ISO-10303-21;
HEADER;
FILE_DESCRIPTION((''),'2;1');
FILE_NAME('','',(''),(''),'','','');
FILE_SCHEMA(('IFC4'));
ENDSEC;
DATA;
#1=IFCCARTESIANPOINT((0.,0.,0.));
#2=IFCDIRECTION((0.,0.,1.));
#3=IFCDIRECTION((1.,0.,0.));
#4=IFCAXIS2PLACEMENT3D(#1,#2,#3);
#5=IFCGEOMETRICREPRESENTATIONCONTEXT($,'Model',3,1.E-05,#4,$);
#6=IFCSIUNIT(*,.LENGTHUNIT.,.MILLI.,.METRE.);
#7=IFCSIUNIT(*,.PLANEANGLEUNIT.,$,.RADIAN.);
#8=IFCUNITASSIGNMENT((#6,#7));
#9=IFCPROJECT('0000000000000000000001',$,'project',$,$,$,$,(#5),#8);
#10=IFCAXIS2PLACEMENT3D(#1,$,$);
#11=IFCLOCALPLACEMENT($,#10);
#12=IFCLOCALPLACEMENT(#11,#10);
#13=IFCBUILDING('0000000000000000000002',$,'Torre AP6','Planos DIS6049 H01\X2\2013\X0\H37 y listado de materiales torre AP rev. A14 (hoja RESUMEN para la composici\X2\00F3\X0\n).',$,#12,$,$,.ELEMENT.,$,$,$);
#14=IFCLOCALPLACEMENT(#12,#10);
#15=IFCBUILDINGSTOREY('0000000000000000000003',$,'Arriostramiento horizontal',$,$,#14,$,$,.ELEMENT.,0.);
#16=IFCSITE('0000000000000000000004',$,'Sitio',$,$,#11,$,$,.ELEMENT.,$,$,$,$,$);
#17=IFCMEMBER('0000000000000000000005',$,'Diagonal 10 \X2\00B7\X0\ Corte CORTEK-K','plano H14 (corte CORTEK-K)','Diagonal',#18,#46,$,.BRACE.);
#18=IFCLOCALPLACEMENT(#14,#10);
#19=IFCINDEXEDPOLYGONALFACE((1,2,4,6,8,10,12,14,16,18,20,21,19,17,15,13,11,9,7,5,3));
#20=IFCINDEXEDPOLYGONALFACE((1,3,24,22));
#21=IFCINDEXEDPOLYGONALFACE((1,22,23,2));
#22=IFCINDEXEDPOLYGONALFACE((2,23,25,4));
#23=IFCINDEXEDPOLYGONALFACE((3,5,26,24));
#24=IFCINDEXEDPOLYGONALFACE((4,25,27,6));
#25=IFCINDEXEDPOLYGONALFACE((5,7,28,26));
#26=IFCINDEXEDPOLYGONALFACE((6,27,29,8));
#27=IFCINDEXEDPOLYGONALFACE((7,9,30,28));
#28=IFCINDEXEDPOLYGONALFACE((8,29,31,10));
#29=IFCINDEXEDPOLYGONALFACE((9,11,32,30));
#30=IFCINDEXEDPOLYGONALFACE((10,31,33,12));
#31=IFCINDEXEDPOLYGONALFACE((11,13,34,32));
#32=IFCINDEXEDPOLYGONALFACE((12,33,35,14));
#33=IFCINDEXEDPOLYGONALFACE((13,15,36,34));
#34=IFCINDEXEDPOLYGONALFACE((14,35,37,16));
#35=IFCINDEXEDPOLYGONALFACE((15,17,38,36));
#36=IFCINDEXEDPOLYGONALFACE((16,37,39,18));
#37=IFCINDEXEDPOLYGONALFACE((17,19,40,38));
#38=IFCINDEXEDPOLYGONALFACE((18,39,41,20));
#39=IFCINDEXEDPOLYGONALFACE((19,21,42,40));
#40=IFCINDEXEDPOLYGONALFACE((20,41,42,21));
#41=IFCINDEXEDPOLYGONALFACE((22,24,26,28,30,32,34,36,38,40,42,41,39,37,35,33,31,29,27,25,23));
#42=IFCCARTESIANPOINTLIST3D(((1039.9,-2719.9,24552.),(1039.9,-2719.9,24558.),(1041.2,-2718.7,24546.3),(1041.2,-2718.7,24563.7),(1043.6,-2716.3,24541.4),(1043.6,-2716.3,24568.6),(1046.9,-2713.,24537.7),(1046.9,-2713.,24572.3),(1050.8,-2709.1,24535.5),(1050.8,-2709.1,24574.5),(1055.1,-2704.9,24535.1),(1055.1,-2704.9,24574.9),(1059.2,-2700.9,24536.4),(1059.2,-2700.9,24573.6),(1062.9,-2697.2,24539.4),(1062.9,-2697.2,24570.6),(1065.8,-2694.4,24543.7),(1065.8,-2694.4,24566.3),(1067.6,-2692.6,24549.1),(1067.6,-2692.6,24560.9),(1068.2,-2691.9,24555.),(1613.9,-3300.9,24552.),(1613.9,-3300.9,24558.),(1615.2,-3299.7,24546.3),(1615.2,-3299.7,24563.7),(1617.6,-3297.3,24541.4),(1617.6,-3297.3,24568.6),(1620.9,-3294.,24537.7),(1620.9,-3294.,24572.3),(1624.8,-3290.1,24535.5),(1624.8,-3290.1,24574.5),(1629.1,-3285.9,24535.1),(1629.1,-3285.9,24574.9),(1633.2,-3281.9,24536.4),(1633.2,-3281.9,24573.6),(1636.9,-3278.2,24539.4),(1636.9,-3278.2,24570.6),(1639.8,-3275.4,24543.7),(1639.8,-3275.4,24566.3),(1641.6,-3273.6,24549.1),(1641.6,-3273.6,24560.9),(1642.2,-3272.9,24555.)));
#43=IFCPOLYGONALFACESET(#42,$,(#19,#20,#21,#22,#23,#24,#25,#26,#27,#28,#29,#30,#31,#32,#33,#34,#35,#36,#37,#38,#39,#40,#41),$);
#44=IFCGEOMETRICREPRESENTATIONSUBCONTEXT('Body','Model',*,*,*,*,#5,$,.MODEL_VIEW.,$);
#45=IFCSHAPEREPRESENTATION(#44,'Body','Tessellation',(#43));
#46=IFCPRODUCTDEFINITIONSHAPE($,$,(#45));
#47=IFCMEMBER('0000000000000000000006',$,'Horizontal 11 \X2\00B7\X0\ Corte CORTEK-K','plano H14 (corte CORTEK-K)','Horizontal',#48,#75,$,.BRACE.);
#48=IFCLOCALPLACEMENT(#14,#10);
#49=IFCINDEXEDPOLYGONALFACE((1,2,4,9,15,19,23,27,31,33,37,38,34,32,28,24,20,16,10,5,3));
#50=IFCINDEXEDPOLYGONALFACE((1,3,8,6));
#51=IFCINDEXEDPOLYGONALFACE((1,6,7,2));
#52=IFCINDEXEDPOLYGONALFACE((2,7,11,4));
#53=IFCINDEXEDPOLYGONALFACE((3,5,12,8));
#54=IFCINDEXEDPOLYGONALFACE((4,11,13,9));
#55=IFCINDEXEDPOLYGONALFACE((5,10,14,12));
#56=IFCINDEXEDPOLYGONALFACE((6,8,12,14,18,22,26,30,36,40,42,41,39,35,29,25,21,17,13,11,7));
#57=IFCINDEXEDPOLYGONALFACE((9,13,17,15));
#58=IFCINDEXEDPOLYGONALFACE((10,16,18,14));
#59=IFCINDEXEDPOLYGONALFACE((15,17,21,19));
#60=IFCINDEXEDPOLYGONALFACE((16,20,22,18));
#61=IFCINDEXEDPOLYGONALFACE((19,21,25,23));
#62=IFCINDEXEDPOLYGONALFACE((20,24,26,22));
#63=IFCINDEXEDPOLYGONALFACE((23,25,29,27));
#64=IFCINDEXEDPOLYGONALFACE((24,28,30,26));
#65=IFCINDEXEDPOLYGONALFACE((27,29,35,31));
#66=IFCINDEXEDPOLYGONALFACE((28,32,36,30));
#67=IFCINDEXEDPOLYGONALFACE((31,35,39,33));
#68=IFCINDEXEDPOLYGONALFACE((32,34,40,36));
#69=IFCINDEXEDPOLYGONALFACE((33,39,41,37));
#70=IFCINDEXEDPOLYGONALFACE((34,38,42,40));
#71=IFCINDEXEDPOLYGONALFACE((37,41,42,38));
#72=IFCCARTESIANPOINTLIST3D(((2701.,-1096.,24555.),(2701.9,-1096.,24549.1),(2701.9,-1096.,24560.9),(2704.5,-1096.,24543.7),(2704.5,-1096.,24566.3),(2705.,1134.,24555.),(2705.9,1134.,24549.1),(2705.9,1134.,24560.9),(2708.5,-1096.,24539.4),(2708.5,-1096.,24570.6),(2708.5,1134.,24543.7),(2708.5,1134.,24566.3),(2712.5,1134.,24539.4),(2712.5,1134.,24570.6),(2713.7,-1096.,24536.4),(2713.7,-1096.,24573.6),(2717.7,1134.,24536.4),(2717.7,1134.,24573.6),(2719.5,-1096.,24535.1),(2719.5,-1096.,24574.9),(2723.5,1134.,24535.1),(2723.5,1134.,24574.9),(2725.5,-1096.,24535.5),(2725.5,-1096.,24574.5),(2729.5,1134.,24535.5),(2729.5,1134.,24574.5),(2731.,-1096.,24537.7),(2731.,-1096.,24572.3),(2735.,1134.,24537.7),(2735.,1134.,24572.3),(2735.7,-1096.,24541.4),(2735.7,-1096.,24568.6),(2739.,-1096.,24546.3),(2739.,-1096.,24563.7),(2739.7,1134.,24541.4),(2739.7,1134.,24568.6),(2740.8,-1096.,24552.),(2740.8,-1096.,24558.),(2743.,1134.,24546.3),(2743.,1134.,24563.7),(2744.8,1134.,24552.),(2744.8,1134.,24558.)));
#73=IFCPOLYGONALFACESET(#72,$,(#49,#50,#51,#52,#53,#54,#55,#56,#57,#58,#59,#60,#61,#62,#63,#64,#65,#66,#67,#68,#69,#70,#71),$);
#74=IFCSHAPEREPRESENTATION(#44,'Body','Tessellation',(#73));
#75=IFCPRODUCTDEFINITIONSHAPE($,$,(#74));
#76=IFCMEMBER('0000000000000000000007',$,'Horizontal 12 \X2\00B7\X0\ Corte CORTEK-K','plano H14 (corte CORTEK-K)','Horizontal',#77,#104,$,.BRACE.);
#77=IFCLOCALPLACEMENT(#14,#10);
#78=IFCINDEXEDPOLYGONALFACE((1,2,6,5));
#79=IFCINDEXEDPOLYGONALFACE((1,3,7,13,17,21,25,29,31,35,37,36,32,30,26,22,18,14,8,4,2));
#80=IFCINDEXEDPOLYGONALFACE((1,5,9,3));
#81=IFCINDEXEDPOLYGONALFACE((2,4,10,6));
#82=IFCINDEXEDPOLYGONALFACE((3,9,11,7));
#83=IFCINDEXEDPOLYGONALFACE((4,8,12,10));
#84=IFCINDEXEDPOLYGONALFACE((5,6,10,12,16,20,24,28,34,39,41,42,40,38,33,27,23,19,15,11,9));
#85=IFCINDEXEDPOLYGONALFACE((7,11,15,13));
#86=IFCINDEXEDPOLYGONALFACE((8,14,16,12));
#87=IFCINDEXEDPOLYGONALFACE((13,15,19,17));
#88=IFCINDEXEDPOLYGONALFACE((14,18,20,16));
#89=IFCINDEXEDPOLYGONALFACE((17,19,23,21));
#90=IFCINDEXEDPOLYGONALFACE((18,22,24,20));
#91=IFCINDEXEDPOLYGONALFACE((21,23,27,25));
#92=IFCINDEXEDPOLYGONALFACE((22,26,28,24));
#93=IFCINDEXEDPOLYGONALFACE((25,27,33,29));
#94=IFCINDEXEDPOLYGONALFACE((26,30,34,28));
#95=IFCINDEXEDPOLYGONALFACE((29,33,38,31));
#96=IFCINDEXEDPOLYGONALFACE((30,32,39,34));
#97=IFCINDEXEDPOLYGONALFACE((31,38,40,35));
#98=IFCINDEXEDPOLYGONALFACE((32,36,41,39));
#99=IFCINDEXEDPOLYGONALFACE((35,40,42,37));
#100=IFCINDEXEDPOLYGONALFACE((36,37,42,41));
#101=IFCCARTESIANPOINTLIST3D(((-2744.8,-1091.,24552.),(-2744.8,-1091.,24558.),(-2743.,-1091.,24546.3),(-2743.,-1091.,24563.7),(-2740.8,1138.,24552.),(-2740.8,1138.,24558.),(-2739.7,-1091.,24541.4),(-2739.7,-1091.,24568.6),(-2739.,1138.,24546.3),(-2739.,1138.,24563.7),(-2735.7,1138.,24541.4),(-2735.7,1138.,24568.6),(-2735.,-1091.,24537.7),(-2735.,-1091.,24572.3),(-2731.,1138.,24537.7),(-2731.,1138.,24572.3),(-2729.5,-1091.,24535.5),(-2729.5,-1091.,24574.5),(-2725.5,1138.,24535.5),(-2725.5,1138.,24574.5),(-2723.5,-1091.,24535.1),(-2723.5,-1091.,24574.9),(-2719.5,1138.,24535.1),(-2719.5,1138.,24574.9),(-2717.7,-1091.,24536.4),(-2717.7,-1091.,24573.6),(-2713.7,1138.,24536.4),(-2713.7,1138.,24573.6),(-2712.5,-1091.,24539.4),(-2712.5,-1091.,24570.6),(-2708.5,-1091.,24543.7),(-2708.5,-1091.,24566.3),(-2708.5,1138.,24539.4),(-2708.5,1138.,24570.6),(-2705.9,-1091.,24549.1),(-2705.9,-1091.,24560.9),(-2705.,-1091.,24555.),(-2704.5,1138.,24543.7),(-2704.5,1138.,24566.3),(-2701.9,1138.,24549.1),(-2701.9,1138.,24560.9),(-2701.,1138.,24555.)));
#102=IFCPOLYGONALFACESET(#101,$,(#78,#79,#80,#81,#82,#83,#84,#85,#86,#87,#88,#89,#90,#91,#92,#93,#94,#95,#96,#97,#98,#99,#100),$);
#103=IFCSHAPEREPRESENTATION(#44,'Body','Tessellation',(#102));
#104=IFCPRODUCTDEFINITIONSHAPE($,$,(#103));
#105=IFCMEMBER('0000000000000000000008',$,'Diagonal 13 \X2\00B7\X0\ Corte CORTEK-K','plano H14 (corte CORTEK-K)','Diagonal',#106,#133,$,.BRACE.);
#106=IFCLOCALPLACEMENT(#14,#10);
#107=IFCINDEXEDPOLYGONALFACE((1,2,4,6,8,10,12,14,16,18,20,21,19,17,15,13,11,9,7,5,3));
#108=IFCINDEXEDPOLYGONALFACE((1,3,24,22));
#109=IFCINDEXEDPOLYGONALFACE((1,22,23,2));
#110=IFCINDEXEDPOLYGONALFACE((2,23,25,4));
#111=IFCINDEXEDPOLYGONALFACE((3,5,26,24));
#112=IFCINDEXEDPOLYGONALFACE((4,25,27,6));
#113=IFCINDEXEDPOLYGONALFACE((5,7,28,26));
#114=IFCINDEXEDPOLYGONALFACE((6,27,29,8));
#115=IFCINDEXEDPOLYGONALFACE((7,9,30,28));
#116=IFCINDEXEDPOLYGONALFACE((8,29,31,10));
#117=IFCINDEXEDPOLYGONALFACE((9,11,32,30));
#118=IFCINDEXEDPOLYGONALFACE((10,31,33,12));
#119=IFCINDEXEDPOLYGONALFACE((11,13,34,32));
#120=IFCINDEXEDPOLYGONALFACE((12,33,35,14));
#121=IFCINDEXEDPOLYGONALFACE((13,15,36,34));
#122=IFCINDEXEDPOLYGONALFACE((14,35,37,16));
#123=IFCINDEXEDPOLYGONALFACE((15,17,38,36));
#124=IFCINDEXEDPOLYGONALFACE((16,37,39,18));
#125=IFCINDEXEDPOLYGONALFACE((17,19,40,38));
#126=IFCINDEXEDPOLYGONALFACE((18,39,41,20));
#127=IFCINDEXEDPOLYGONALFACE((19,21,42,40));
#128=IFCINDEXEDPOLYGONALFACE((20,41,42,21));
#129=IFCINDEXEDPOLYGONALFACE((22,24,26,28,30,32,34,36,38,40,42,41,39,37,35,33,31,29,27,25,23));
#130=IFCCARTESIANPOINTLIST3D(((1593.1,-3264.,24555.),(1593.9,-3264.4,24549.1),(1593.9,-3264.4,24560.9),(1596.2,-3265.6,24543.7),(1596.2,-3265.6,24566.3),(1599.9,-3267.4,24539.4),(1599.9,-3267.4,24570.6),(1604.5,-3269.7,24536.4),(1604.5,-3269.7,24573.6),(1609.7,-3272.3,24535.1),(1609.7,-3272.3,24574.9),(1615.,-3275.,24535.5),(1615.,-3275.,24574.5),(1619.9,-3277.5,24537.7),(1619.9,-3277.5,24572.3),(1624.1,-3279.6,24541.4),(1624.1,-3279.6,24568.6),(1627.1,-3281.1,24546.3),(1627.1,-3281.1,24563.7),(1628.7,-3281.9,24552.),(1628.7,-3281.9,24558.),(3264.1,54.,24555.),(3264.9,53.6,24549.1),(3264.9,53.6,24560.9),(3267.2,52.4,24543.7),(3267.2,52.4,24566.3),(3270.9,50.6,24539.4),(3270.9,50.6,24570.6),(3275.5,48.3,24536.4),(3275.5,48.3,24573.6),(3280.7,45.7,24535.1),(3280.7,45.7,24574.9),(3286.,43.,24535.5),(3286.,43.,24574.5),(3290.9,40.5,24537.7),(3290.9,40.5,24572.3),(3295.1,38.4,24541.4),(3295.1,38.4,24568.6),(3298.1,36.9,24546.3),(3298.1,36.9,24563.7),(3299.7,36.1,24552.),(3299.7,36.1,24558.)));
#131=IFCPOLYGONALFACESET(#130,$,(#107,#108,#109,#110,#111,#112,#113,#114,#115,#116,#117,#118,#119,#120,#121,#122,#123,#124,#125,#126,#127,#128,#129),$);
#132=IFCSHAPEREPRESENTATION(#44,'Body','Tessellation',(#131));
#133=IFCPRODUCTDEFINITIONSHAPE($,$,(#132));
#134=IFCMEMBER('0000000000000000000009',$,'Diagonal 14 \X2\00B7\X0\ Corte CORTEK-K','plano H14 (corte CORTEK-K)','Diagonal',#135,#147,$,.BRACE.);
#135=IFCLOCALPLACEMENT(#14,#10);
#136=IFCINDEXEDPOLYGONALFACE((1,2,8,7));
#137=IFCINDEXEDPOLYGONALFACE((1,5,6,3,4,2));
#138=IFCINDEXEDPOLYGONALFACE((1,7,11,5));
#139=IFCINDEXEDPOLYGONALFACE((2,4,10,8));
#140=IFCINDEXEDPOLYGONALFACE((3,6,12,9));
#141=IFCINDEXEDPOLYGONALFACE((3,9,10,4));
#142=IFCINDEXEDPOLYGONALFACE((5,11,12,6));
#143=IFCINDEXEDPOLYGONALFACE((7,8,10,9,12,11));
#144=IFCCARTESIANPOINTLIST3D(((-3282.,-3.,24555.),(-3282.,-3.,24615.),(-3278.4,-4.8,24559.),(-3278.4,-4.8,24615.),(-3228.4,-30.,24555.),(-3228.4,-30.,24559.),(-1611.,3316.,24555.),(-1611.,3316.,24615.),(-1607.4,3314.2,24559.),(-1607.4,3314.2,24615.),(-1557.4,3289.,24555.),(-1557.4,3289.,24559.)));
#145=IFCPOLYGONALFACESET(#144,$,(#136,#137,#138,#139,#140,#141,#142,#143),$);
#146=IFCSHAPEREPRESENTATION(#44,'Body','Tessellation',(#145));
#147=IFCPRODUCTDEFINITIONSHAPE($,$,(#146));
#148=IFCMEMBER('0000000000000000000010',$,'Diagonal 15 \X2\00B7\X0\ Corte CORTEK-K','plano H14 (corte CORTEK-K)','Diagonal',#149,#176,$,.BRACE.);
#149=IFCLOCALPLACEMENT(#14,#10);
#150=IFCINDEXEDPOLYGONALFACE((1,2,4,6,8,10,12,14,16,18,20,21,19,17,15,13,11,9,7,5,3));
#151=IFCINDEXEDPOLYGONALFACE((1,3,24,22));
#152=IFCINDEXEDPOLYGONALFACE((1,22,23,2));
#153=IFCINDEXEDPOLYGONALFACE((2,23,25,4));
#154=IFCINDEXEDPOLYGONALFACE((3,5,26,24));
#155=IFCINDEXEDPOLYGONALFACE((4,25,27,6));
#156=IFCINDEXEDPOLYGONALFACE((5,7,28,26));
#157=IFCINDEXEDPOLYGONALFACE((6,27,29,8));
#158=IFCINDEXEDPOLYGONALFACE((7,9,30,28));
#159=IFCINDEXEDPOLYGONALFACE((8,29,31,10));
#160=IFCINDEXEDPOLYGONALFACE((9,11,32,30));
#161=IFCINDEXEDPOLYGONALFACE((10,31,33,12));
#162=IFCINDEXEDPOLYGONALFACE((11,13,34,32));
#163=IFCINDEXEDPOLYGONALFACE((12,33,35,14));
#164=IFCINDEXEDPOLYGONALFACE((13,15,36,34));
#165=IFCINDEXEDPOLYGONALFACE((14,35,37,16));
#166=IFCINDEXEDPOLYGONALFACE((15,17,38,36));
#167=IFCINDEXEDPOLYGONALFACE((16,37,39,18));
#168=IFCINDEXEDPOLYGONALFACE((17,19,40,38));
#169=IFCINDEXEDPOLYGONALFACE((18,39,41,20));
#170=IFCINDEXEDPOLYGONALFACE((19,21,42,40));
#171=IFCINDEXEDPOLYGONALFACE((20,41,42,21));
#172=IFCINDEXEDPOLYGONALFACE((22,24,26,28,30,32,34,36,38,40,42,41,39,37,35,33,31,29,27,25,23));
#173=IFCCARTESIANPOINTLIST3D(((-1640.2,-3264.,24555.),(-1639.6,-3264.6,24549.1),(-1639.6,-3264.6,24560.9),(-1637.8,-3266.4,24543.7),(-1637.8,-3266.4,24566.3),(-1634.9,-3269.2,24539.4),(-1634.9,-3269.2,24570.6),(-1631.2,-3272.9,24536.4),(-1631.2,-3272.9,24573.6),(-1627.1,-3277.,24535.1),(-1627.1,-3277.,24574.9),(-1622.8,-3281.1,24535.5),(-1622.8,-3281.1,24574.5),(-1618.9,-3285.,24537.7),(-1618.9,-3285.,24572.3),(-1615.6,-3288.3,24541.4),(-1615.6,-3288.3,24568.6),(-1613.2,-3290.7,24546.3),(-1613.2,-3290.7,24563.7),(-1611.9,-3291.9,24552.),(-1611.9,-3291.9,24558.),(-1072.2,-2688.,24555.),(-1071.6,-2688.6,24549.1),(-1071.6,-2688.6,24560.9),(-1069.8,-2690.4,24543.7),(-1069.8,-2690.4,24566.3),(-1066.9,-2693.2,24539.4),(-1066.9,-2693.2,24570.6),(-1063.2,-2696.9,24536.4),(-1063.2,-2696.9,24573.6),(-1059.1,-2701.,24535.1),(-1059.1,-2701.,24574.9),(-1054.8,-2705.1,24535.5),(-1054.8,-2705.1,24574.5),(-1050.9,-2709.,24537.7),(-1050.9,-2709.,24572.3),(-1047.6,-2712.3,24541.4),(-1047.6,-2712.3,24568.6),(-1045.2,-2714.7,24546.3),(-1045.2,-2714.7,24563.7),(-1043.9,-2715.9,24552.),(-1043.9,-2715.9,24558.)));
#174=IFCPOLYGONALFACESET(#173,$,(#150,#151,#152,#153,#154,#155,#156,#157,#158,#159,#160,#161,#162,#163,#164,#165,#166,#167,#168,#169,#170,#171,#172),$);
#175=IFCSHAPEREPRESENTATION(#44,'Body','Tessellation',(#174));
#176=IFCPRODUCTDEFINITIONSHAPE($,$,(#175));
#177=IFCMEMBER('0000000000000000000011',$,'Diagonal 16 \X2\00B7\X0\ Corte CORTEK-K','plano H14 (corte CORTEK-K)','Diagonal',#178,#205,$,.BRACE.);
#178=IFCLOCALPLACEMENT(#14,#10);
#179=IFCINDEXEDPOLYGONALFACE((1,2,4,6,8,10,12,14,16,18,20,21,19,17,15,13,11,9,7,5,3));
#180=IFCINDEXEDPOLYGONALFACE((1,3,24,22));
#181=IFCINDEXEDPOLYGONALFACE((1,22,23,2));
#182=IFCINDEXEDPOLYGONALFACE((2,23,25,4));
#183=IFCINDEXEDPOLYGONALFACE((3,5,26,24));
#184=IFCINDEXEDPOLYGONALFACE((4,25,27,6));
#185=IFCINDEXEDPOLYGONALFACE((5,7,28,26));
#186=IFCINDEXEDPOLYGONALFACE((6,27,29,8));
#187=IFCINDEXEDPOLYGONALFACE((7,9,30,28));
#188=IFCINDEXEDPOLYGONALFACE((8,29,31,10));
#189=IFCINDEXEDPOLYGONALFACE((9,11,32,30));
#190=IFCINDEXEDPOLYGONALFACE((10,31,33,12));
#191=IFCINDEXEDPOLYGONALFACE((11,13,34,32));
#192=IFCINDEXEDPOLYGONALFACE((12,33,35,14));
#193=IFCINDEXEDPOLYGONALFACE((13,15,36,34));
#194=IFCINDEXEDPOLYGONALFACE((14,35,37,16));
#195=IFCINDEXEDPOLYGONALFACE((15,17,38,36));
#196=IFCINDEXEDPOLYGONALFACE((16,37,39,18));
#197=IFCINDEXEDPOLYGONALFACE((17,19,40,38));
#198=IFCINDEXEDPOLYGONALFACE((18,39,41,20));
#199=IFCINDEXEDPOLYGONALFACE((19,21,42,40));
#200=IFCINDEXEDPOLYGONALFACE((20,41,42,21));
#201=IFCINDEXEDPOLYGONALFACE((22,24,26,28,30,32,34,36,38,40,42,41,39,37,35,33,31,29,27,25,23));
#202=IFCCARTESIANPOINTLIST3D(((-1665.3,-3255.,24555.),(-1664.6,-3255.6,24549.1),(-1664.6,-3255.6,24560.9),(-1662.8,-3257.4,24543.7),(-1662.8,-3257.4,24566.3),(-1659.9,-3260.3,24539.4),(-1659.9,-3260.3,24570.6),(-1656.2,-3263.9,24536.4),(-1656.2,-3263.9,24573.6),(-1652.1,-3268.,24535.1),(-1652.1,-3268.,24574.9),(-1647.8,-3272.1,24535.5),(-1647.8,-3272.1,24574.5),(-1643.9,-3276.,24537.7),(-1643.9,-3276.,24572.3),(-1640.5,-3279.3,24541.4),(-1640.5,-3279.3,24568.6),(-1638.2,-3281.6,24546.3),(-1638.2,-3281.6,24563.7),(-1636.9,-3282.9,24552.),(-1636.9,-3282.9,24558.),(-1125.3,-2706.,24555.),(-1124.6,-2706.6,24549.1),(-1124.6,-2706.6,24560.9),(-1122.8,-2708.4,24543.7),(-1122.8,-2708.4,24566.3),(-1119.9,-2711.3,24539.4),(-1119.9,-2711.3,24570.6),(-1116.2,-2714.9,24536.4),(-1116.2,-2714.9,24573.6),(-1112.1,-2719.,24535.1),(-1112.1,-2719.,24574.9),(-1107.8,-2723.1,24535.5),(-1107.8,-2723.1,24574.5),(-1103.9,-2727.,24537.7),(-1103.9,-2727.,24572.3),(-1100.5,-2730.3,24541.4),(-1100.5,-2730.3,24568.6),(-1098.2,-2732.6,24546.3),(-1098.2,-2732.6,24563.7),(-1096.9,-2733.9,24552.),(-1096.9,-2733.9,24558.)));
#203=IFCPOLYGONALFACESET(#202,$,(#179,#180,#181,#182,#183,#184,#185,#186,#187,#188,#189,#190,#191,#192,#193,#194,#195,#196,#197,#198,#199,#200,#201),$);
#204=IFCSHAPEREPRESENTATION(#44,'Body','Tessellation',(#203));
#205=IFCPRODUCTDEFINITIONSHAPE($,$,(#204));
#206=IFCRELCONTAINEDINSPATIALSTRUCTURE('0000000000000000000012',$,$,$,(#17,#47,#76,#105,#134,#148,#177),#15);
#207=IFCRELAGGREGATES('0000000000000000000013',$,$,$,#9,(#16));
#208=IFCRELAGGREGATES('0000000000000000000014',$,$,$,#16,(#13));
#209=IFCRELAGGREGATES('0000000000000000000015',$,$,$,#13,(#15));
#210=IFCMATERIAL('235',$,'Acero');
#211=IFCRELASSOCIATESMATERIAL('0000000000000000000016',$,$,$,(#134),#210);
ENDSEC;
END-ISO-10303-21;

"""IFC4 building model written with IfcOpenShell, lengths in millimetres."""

from ifc_helpers import new_model, si_unit, frame, frame_2d, origin, origin_with_axes, place, context, subcontext, project, spatial, circle, l_section, extrude, material, element, save


model = new_model("IFC4")

# Units and contexts
model_context = context("Model", 3, precision=1e-05, world=origin_with_axes())
body_context = subcontext(model_context, "Body", "Model", "MODEL_VIEW")
ifc_project = project(units=[si_unit("LENGTHUNIT", "METRE", prefix="MILLI"), si_unit("PLANEANGLEUNIT", "RADIAN")], contexts=[model_context])

# Site, building, storey
site_placement = place(None, origin())
site = spatial("IfcSite", under=ifc_project, at=site_placement, Name="Sitio", CompositionType="ELEMENT")
building_placement = place(site_placement, origin())
building = spatial("IfcBuilding", under=site, at=building_placement, Name="Torre AP6", Description="Planos DIS6049 H01–H37 y listado de materiales torre AP rev. A14 (hoja RESUMEN para la composición).", CompositionType="ELEMENT")
storey_placement = place(building_placement, origin())
storey = spatial("IfcBuildingStorey", under=building, at=storey_placement, Name="Arriostramiento horizontal", CompositionType="ELEMENT", Elevation=0.0)

# Members
ifc_material = material(Name="235", Category="Acero")
member_1_placement = place(storey_placement, frame((1054.0, -2706.0, 24555.0), z_axis=(0.702808, -0.711379, 0.0), x_axis=(0.711379, 0.702808, 0.0)))
element("IfcMember", 1, at=member_1_placement, inside=storey, Name="Diagonal 10 · Corte CORTEK-K", Description="plano H14 (corte CORTEK-K)", ObjectType="Diagonal", PredefinedType="BRACE", context=body_context, shape_type="SweptSolid", body=[
    extrude(circle(Radius=20.0), None, (0.0, 0.0, 1.0), 816.7),
])
member_2_placement = place(storey_placement, frame((2725.0, 1134.0, 24555.0), z_axis=(-0.001794, -0.999998, 0.0), x_axis=(-0.999998, 0.001794, 0.0)))
element("IfcMember", 2, at=member_2_placement, inside=storey, Name="Horizontal 11 · Corte CORTEK-K", Description="plano H14 (corte CORTEK-K)", ObjectType="Horizontal", PredefinedType="BRACE", context=body_context, shape_type="SweptSolid", body=[
    extrude(circle(Radius=20.0), None, (0.0, 0.0, 1.0), 2230.0),
])
member_3_placement = place(storey_placement, frame((-2721.0, 1138.0, 24555.0), z_axis=(-0.001795, -0.999998, 0.0), x_axis=(0.999998, -0.001795, 0.0)))
element("IfcMember", 3, at=member_3_placement, inside=storey, Name="Horizontal 12 · Corte CORTEK-K", Description="plano H14 (corte CORTEK-K)", ObjectType="Horizontal", PredefinedType="BRACE", context=body_context, shape_type="SweptSolid", body=[
    extrude(circle(Radius=20.0), None, (0.0, 0.0, 1.0), 2229.0),
])
member_4_placement = place(storey_placement, frame((3282.0, 45.0, 24555.0), z_axis=(-0.449796, -0.893131, 0.0), x_axis=(-0.893131, 0.449796, 0.0)))
element("IfcMember", 4, at=member_4_placement, inside=storey, Name="Diagonal 13 · Corte CORTEK-K", Description="plano H14 (corte CORTEK-K)", ObjectType="Diagonal", PredefinedType="BRACE", context=body_context, shape_type="SweptSolid", body=[
    extrude(circle(Radius=20.0), None, (0.0, 0.0, 1.0), 3715.0),
])
member_5_placement = place(storey_placement, frame((-1611.0, 3316.0, 24555.0), z_axis=(-0.449688, -0.893186, 0.0), x_axis=(0.893186, -0.449688, 0.0)))
element("IfcMember", 5, at=member_5_placement, inside=storey, material=ifc_material, Name="Diagonal 14 · Corte CORTEK-K", Description="plano H14 (corte CORTEK-K)", ObjectType="Diagonal", PredefinedType="BRACE", context=body_context, shape_type="SweptSolid", body=[
    extrude(l_section(Depth=60.0, Width=60.0, Thickness=4.0, at=frame_2d((30.0, 30.0))), None, (0.0, 0.0, 1.0), 3715.9),
])
member_6_placement = place(storey_placement, frame((-1058.0, -2702.0, 24555.0), z_axis=(-0.702145, -0.712034, 0.0), x_axis=(-0.712034, 0.702145, 0.0)))
element("IfcMember", 6, at=member_6_placement, inside=storey, Name="Diagonal 15 · Corte CORTEK-K", Description="plano H14 (corte CORTEK-K)", ObjectType="Diagonal", PredefinedType="BRACE", context=body_context, shape_type="SweptSolid", body=[
    extrude(circle(Radius=20.0), None, (0.0, 0.0, 1.0), 808.9),
])
member_7_placement = place(storey_placement, frame((-1111.0, -2720.0, 24555.0), z_axis=(-0.701239, -0.712926, 0.0), x_axis=(-0.712926, 0.701239, 0.0)))
element("IfcMember", 7, at=member_7_placement, inside=storey, Name="Diagonal 16 · Corte CORTEK-K", Description="plano H14 (corte CORTEK-K)", ObjectType="Diagonal", PredefinedType="BRACE", context=body_context, shape_type="SweptSolid", body=[
    extrude(circle(Radius=20.0), None, (0.0, 0.0, 1.0), 770.1),
])

save(model, "model.ifc")
